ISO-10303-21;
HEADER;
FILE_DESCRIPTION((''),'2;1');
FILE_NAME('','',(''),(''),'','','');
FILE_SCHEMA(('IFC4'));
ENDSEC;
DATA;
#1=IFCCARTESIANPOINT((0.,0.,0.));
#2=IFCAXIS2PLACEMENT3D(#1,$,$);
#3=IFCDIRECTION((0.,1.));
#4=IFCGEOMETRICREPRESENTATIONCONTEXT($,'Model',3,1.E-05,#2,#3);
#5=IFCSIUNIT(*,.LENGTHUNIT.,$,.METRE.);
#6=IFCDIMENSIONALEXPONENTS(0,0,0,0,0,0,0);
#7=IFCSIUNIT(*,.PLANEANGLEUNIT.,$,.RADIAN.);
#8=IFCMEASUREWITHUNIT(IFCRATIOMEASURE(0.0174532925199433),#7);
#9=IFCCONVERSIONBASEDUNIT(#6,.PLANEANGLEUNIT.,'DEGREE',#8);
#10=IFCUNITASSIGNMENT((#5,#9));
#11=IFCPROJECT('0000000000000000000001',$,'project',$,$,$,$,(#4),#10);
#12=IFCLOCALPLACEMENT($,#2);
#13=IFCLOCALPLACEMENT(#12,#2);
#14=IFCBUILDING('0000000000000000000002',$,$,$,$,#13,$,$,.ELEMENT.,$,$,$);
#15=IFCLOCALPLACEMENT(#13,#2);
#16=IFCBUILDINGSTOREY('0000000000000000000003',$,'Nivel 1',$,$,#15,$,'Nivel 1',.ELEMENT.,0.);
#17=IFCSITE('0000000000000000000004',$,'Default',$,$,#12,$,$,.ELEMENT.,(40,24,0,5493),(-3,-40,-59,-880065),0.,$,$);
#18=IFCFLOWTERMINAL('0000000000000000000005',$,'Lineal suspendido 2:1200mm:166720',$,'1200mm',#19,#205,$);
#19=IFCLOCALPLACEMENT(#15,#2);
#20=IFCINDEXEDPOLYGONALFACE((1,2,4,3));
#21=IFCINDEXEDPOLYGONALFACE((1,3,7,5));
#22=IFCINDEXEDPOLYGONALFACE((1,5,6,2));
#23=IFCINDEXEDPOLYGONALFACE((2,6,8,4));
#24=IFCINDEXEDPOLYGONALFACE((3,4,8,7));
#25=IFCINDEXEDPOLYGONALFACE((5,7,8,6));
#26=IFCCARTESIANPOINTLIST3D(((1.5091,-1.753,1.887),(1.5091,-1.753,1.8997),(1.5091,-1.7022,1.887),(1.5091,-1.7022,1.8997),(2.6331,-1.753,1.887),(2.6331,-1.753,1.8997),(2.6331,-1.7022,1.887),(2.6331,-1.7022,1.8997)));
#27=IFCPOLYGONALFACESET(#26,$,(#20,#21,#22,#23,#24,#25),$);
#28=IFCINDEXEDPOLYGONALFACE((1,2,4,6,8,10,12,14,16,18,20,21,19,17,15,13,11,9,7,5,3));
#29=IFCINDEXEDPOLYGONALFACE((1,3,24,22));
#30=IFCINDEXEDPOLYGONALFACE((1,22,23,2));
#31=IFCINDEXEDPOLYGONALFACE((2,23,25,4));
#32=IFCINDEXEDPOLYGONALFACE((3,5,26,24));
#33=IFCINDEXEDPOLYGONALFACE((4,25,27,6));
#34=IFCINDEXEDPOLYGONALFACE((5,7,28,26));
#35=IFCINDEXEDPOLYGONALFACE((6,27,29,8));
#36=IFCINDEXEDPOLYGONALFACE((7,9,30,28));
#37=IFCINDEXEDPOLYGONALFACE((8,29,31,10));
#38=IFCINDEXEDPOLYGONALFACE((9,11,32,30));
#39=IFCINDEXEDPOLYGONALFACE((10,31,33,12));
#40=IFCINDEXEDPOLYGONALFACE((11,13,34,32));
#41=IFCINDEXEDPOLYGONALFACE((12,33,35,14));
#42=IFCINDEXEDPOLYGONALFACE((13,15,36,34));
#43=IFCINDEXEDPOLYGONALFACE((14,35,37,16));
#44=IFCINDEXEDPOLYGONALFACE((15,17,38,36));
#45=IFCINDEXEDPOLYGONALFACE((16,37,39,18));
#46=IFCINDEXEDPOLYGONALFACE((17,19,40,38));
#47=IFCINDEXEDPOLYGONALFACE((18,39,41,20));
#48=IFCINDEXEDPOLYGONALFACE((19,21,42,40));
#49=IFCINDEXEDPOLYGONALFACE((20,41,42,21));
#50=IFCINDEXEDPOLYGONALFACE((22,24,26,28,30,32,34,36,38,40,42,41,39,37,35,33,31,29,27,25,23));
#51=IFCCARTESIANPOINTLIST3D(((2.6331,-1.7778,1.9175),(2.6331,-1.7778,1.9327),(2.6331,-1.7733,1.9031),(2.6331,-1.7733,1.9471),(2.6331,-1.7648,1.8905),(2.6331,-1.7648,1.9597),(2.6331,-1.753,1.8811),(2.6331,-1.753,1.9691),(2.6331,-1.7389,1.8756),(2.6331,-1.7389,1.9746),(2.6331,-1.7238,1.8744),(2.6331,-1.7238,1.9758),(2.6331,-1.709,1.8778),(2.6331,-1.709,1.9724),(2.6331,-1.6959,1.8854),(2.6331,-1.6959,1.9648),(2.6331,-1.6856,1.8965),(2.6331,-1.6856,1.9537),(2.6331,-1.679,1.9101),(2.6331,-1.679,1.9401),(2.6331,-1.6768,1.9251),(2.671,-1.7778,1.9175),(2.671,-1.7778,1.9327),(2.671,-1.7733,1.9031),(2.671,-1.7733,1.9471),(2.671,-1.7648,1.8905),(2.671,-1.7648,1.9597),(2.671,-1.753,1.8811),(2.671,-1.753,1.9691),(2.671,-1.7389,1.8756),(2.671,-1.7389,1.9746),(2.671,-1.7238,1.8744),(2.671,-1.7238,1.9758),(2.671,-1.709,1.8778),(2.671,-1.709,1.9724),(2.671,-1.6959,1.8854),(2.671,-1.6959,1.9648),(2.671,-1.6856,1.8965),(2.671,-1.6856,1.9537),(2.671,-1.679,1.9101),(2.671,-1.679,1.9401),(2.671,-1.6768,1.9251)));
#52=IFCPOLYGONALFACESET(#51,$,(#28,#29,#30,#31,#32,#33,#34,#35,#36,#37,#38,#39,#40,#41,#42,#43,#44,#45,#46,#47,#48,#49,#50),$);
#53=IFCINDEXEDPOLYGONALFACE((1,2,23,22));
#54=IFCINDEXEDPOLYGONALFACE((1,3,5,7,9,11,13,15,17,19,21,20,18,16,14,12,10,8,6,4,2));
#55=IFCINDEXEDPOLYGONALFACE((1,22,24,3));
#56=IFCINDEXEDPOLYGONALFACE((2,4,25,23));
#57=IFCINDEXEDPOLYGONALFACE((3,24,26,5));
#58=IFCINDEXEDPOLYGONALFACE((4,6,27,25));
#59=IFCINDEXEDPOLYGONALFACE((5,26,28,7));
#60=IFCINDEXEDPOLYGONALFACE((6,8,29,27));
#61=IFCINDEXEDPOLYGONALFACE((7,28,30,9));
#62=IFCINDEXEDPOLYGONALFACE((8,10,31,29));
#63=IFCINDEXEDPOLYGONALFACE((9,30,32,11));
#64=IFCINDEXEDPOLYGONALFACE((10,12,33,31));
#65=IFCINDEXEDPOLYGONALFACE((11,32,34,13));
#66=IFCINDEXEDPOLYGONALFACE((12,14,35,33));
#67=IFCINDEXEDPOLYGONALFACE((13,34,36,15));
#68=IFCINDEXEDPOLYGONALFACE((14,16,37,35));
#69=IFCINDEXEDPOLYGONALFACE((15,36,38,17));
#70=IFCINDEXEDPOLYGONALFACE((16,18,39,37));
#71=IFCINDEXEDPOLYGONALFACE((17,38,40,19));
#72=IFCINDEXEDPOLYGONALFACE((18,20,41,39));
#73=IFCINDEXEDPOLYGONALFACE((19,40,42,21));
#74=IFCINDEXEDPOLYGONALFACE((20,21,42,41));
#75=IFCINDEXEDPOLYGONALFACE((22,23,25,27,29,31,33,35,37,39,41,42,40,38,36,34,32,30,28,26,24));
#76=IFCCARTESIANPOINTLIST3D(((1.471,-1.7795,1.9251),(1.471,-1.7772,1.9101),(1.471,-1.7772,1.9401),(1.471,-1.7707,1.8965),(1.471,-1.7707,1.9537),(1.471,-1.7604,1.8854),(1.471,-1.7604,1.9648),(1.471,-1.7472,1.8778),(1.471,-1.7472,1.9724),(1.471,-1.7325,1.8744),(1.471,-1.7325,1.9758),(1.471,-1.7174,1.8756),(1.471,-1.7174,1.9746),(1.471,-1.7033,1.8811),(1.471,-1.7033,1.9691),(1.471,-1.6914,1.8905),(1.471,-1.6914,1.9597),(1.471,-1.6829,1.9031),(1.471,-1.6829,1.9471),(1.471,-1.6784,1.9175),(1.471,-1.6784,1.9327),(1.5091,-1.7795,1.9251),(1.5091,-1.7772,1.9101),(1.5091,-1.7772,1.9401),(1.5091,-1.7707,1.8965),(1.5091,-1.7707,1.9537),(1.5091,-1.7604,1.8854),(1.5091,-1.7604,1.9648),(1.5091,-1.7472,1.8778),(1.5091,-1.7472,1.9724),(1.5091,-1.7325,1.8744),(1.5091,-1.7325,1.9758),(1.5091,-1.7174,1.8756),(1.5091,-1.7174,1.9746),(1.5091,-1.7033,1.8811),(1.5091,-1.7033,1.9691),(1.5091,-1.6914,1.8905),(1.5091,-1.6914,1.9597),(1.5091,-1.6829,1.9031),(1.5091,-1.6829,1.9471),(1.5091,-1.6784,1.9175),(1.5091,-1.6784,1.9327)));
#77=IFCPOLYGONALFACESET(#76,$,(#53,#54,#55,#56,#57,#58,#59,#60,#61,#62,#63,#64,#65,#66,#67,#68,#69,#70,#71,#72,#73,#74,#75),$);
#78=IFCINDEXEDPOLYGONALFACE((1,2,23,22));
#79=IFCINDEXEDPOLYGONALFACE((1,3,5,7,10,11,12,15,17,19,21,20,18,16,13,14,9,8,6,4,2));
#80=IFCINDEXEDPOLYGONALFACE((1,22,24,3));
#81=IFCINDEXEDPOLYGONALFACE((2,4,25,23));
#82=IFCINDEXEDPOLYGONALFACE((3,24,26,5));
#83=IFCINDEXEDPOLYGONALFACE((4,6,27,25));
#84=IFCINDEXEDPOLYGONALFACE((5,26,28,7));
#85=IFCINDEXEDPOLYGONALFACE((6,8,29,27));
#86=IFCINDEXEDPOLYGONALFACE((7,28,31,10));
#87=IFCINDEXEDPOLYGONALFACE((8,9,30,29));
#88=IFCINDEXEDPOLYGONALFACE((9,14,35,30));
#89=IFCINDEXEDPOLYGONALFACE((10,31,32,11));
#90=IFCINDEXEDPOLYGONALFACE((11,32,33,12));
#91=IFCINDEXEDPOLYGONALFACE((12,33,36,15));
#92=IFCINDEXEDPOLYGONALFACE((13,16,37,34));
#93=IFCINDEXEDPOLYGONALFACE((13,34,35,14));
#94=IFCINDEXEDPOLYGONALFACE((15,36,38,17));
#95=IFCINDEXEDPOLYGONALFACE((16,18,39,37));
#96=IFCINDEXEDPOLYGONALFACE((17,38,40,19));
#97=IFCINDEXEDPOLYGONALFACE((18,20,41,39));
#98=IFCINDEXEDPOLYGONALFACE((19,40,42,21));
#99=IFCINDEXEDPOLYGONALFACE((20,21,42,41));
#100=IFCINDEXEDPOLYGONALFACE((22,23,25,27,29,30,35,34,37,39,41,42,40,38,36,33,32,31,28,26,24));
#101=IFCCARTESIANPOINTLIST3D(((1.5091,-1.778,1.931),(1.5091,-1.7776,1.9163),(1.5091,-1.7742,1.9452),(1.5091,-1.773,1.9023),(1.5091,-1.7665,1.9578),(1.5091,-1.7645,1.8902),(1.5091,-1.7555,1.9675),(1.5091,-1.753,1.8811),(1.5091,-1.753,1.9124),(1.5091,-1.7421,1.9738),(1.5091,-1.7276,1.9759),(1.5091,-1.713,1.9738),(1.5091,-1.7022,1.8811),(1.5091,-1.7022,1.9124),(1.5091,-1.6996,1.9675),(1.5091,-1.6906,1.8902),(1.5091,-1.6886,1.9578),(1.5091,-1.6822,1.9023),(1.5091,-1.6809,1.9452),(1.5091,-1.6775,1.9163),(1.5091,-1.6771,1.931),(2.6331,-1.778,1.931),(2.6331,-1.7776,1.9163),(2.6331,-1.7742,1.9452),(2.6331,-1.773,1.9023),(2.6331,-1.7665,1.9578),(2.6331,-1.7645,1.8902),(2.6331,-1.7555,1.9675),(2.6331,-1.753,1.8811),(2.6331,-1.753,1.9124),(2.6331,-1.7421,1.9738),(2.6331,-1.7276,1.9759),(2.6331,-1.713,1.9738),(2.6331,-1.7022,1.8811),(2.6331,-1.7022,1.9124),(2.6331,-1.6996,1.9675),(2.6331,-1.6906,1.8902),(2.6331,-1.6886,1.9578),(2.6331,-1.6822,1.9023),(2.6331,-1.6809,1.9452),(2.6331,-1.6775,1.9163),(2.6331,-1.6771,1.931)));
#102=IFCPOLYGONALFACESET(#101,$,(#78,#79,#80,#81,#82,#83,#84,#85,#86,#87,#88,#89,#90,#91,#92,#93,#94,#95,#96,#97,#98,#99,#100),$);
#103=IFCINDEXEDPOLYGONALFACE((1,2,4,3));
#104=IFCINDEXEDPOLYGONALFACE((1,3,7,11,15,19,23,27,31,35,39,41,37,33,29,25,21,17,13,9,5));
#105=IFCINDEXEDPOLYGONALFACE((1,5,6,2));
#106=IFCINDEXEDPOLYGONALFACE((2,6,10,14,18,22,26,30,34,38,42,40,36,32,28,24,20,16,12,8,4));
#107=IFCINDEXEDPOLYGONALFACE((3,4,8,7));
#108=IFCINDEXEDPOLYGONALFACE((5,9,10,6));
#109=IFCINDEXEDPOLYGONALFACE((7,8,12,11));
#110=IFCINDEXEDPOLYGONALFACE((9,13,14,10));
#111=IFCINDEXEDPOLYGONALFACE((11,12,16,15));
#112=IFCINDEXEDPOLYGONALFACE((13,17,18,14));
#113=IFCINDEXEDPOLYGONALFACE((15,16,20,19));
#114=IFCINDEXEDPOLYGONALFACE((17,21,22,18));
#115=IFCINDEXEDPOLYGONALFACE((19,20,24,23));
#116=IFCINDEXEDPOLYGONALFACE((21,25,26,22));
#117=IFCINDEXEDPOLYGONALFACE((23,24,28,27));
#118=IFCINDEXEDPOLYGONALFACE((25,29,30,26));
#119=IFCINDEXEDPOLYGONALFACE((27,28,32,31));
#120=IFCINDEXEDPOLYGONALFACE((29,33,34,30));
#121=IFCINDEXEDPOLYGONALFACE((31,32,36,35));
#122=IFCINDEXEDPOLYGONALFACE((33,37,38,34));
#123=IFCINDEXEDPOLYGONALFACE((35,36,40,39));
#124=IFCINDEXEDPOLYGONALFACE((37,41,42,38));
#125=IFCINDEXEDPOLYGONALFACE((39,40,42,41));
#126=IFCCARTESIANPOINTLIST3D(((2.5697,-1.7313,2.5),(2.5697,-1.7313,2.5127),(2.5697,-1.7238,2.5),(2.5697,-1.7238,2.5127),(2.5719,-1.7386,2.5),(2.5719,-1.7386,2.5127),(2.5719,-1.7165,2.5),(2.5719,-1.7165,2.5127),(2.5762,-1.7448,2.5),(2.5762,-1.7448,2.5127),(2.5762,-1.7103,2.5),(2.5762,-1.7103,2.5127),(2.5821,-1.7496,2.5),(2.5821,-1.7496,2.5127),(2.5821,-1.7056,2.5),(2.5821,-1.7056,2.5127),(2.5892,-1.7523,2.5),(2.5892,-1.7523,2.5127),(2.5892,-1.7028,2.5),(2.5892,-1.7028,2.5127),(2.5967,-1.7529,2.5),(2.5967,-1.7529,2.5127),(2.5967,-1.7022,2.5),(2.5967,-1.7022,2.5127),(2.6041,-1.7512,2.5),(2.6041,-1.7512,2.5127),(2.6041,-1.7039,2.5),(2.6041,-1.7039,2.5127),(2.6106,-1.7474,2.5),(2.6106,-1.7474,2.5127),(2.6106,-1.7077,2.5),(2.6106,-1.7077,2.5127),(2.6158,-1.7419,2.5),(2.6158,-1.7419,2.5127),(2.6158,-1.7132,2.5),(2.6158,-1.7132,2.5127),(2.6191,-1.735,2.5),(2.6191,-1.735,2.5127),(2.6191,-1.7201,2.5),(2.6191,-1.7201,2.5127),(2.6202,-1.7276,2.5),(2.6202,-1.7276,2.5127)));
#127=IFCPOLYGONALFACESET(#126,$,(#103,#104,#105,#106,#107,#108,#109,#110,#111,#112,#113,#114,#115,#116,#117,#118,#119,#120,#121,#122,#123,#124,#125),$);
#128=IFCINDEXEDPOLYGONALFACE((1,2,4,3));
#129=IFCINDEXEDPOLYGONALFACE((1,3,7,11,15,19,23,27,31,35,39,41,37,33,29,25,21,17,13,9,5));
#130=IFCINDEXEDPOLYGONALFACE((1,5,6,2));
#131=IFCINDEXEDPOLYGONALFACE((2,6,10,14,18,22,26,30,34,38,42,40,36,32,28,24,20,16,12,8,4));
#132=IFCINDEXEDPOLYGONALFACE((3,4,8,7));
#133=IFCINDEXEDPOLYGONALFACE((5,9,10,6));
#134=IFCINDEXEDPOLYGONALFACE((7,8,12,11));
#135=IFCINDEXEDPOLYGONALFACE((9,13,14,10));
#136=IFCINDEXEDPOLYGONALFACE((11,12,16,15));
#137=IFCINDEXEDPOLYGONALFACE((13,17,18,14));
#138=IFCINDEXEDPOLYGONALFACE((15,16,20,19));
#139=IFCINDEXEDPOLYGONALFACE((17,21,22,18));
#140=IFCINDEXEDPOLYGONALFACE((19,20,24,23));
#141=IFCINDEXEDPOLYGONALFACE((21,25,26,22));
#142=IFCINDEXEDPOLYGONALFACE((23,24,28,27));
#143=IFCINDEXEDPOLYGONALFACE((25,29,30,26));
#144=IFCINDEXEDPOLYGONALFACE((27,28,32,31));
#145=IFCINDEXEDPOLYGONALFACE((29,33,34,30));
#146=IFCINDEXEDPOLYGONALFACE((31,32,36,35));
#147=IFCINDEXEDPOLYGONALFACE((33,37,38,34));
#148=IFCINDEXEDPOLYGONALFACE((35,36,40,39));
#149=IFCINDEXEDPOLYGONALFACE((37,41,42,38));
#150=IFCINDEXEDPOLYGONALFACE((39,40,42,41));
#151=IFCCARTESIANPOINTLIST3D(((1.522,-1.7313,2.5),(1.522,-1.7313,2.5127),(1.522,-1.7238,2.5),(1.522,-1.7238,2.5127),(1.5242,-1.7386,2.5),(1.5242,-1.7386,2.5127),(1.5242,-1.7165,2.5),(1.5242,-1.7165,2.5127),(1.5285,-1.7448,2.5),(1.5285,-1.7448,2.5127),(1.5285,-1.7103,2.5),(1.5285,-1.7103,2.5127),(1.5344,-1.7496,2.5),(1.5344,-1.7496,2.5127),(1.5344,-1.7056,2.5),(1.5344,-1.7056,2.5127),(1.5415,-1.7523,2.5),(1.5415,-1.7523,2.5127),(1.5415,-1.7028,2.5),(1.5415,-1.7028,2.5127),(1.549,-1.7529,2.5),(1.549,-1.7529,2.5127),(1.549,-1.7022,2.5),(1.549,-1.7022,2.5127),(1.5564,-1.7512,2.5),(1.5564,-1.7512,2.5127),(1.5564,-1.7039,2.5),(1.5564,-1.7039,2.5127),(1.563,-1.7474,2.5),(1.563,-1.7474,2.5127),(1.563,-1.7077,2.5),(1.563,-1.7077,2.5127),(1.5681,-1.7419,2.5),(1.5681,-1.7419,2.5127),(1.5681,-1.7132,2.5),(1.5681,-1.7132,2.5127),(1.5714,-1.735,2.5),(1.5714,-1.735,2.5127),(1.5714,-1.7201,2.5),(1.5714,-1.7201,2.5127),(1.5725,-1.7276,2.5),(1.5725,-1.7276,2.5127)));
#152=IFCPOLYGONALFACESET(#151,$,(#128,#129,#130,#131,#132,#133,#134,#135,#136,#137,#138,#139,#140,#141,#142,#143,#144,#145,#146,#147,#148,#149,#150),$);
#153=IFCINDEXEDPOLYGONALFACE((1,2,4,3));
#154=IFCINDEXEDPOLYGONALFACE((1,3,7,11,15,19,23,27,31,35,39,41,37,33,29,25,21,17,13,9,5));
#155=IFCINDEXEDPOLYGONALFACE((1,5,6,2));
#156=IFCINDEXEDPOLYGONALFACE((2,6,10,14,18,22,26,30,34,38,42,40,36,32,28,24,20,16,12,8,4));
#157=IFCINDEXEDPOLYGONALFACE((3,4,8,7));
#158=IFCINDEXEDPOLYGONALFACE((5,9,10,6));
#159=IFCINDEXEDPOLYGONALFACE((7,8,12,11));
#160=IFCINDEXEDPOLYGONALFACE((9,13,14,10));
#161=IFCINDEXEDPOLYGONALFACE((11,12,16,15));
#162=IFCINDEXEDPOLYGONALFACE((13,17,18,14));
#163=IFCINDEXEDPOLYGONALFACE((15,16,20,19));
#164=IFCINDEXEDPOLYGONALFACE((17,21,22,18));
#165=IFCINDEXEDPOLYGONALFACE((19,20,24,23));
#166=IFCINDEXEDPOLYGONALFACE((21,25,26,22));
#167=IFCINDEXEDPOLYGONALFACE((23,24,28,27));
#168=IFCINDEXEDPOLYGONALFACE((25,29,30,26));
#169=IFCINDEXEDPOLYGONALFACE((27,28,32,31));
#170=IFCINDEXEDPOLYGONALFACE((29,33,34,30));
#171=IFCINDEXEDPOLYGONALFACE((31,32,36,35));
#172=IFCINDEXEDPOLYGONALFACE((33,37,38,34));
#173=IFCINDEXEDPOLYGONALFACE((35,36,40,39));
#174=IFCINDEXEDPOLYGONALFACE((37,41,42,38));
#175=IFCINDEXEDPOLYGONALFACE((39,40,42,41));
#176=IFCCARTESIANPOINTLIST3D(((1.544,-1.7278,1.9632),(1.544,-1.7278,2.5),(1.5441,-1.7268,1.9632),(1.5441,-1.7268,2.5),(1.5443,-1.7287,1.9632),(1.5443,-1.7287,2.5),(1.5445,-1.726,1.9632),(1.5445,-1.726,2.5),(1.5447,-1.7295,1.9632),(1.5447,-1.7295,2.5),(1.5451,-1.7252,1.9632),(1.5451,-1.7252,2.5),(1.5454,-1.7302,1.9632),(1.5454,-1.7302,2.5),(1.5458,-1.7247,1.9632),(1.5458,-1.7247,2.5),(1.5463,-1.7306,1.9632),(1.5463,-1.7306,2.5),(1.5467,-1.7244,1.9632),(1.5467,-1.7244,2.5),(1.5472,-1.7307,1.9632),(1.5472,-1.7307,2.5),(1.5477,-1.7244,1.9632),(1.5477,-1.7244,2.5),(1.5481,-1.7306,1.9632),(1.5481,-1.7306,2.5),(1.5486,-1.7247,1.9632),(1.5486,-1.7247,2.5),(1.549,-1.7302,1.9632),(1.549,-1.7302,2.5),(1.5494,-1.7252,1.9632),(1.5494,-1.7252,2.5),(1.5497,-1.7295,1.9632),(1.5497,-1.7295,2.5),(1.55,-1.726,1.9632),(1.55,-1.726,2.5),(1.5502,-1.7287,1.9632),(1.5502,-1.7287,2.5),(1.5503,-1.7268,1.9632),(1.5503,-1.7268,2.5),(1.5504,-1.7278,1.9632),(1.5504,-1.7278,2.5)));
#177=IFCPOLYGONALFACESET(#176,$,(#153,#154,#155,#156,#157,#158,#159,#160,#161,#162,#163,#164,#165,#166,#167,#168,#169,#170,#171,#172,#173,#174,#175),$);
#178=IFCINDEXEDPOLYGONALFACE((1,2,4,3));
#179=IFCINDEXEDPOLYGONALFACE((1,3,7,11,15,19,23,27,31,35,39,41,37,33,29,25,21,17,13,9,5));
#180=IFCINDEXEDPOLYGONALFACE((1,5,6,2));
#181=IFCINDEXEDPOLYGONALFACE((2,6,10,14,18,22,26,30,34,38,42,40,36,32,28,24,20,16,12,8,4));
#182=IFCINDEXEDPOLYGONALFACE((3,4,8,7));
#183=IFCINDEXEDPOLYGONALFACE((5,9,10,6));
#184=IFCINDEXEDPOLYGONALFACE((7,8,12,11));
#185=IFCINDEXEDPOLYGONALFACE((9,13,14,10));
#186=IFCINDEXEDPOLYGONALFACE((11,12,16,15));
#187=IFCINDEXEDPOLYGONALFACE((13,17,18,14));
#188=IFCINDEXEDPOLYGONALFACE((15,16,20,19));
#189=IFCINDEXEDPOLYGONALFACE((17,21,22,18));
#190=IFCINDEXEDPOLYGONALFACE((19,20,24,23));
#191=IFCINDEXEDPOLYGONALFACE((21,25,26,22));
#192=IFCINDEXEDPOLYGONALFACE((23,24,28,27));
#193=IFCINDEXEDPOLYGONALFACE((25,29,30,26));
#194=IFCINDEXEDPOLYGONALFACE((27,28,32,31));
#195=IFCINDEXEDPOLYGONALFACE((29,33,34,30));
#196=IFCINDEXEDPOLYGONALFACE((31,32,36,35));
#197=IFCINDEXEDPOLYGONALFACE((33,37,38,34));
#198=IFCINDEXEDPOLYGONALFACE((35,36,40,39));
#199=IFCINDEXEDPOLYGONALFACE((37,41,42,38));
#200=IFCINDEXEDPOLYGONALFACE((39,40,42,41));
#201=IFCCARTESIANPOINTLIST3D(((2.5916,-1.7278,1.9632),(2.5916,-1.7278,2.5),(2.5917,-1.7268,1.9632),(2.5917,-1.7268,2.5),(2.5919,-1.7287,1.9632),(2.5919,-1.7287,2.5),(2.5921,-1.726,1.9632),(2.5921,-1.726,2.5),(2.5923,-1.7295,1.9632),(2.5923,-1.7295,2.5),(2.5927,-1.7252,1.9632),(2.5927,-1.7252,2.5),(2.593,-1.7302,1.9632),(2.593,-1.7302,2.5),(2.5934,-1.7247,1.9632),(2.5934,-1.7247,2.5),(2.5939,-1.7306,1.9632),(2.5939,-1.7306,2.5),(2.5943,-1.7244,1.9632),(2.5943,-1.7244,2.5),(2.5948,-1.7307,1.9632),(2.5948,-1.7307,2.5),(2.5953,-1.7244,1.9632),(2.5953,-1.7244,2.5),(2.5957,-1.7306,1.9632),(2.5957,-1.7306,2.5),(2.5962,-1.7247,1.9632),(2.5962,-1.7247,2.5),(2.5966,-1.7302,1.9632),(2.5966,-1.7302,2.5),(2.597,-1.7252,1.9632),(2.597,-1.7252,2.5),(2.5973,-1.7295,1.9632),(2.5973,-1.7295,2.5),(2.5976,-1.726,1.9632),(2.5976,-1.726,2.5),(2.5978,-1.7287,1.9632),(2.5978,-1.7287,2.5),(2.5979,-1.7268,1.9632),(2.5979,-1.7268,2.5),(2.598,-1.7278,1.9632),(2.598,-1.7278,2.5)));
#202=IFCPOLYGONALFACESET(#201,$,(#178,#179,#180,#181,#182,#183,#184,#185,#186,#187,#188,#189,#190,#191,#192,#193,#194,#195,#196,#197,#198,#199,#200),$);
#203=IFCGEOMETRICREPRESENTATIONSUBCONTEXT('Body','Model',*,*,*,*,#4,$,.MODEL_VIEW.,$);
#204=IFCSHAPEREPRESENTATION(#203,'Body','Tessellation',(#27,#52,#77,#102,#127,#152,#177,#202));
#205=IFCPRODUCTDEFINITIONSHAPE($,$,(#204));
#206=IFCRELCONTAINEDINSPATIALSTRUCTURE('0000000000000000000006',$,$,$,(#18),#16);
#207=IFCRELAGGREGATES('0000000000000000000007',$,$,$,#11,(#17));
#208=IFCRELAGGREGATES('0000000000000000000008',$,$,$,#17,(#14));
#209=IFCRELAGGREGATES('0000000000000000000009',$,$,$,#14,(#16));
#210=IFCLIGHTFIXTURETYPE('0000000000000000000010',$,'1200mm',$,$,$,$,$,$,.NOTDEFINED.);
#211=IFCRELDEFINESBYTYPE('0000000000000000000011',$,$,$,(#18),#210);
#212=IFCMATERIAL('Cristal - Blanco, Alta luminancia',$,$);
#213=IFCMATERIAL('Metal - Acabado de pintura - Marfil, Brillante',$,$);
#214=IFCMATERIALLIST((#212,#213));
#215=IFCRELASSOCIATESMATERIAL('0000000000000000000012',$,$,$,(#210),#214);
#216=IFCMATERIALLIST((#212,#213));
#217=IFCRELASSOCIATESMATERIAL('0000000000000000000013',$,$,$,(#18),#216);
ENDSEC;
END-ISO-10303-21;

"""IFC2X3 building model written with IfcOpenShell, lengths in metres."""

from ifc_helpers import new_model, entity, si_unit, converted_unit, direction, frame, frame_2d, origin, origin_2d_with_axis, place, context, subcontext, project, spatial, polyline, circle_curve, parameter, trimmed, segment, composite_curve, rectangle, circle, outline, extrude, source, transform, mapped, material, material_list, type_object, type_shapes, element, save


model = new_model("IFC2X3")

# Units and contexts
model_context = context("Model", 3, precision=1e-05, world=origin(), true_north=direction((0.0, 1.0)))
body_context = subcontext(model_context, "Body", "Model", "MODEL_VIEW")
ifc_project = project(units=[si_unit("LENGTHUNIT", "METRE"), converted_unit("PLANEANGLEUNIT", "DEGREE", entity("IfcRatioMeasure", 0.0174532925199433), si_unit("PLANEANGLEUNIT", "RADIAN"), dimensions=[0, 0, 0, 0, 0, 0, 0])], contexts=[model_context])

# Site, building, storey
site_placement = place(None, origin())
site = spatial("IfcSite", under=ifc_project, at=site_placement, Name="Default", CompositionType="ELEMENT", RefLatitude=(40, 24, 0, 5493), RefLongitude=(-3, -40, -59, -880065), RefElevation=0.0)
building_placement = place(site_placement, origin())
building = spatial("IfcBuilding", under=site, at=building_placement, CompositionType="ELEMENT")
storey_placement = place(building_placement, origin())
storey = spatial("IfcBuildingStorey", under=building, at=storey_placement, Name="Nivel 1", LongName="Nivel 1", CompositionType="ELEMENT", Elevation=0.0)

# Flow terminal
ifc_material_1 = material(Name="Cristal - Blanco, Alta luminancia")
ifc_material_2 = material(Name="Metal - Acabado de pintura - Marfil, Brillante")
ifc_material_list_1 = material_list([ifc_material_1, ifc_material_2])
light_fixture_type = type_object("IfcLightFixtureType", Name="1200mm", PredefinedType="NOTDEFINED", material=ifc_material_list_1)
shared_shape = source(origin(), body_context, "Body", "SweptSolid", [
    extrude(rectangle(XDim=1.124, YDim=0.0508, at=origin_2d_with_axis()), frame((0.0001, 0.0, 1.8127), z_axis=(0.0, 0.0, 1.0), x_axis=(-1.0, 0.0, 0.0)), (0.0, 0.0, 1.0), 0.0127),
    extrude(circle(Radius=0.0508, at=frame_2d((0.0, 0.0), x_axis=(1.0, 0.0))), frame((0.5621, 0.0, 1.8508), z_axis=(1.0, 0.0, 0.0), x_axis=(0.0, 1.0, 0.0)), (0.0, 0.0, 1.0), 0.0379),
    extrude(circle(Radius=0.0508, at=frame_2d((0.0, 0.0), x_axis=(1.0, 0.0))), frame((-0.6, -0.0011, 1.8508), z_axis=(1.0, 0.0, 0.0), x_axis=(0.0, -1.0, 0.0)), (0.0, 0.0, 1.0), 0.0381),
    extrude(outline(composite_curve([segment(trimmed(circle_curve(frame_2d((0.0125, 0.0), x_axis=(0.0, 1.0)), 0.0508), [parameter(120.0)], [parameter(270.0)], True, "PARAMETER"), True, "CONTINUOUS"), segment(trimmed(circle_curve(frame_2d((0.0125, 0.0), x_axis=(0.0, 1.0)), 0.0508), [parameter(270.0)], [parameter(60.0)], True, "PARAMETER"), True, "CONTINUOUS"), segment(polyline([(-0.0315, 0.0254), (-0.0002, 0.0254)]), True, "CONTINUOUS"), segment(polyline([(-0.0002, 0.0254), (-0.0002, -0.0254)]), True, "CONTINUOUS"), segment(polyline([(-0.0002, -0.0254), (-0.0315, -0.0254)]), True, "CONTINUOUS")], self_intersect=False)), frame((-0.5619, 0.0, 1.8383), z_axis=(-1.0, 0.0, 0.0), x_axis=(0.0, 0.0, 1.0)), (0.0, 0.0, -1.0), 1.124),
    extrude(circle(Radius=0.0254, at=frame_2d((0.0, 0.0), x_axis=(1.0, 0.0))), frame((0.5238, 0.0, 2.4257)), (0.0, 0.0, 1.0), 0.0127),
    extrude(circle(Radius=0.0254, at=frame_2d((0.0, 0.0), x_axis=(1.0, 0.0))), frame((-0.5239, 0.0, 2.4257)), (0.0, 0.0, 1.0), 0.0127),
    extrude(circle(Radius=0.0032, at=frame_2d((0.0, 0.0), x_axis=(1.0, 0.0))), frame((-0.5238, 0.0, 1.8889), z_axis=(0.0, 0.0, 1.0), x_axis=(0.0, -1.0, 0.0)), (0.0, 0.0, 1.0), 0.5368),
    extrude(circle(Radius=0.0032, at=frame_2d((0.0, 0.0), x_axis=(1.0, 0.0))), frame((0.5238, 0.0, 1.8889), z_axis=(0.0, 0.0, 1.0), x_axis=(0.0, -1.0, 0.0)), (0.0, 0.0, 1.0), 0.5368),
])
type_shapes(light_fixture_type, [shared_shape])
ifc_material_list_2 = material_list([ifc_material_1, ifc_material_2])
flow_terminal_1_placement = place(storey_placement, frame((2.071, -1.7276, 0.0743)))
element("IfcFlowTerminal", 1, at=flow_terminal_1_placement, inside=storey, type_object=light_fixture_type, material=ifc_material_list_2, Name="Lineal suspendido 2:1200mm:166720", ObjectType="1200mm", context=body_context, shape_type="MappedRepresentation", body=[
    mapped(shared_shape, transform((0.0, 0.0, 0.0), scale=1.0)),
])

save(model, "model.ifc")
